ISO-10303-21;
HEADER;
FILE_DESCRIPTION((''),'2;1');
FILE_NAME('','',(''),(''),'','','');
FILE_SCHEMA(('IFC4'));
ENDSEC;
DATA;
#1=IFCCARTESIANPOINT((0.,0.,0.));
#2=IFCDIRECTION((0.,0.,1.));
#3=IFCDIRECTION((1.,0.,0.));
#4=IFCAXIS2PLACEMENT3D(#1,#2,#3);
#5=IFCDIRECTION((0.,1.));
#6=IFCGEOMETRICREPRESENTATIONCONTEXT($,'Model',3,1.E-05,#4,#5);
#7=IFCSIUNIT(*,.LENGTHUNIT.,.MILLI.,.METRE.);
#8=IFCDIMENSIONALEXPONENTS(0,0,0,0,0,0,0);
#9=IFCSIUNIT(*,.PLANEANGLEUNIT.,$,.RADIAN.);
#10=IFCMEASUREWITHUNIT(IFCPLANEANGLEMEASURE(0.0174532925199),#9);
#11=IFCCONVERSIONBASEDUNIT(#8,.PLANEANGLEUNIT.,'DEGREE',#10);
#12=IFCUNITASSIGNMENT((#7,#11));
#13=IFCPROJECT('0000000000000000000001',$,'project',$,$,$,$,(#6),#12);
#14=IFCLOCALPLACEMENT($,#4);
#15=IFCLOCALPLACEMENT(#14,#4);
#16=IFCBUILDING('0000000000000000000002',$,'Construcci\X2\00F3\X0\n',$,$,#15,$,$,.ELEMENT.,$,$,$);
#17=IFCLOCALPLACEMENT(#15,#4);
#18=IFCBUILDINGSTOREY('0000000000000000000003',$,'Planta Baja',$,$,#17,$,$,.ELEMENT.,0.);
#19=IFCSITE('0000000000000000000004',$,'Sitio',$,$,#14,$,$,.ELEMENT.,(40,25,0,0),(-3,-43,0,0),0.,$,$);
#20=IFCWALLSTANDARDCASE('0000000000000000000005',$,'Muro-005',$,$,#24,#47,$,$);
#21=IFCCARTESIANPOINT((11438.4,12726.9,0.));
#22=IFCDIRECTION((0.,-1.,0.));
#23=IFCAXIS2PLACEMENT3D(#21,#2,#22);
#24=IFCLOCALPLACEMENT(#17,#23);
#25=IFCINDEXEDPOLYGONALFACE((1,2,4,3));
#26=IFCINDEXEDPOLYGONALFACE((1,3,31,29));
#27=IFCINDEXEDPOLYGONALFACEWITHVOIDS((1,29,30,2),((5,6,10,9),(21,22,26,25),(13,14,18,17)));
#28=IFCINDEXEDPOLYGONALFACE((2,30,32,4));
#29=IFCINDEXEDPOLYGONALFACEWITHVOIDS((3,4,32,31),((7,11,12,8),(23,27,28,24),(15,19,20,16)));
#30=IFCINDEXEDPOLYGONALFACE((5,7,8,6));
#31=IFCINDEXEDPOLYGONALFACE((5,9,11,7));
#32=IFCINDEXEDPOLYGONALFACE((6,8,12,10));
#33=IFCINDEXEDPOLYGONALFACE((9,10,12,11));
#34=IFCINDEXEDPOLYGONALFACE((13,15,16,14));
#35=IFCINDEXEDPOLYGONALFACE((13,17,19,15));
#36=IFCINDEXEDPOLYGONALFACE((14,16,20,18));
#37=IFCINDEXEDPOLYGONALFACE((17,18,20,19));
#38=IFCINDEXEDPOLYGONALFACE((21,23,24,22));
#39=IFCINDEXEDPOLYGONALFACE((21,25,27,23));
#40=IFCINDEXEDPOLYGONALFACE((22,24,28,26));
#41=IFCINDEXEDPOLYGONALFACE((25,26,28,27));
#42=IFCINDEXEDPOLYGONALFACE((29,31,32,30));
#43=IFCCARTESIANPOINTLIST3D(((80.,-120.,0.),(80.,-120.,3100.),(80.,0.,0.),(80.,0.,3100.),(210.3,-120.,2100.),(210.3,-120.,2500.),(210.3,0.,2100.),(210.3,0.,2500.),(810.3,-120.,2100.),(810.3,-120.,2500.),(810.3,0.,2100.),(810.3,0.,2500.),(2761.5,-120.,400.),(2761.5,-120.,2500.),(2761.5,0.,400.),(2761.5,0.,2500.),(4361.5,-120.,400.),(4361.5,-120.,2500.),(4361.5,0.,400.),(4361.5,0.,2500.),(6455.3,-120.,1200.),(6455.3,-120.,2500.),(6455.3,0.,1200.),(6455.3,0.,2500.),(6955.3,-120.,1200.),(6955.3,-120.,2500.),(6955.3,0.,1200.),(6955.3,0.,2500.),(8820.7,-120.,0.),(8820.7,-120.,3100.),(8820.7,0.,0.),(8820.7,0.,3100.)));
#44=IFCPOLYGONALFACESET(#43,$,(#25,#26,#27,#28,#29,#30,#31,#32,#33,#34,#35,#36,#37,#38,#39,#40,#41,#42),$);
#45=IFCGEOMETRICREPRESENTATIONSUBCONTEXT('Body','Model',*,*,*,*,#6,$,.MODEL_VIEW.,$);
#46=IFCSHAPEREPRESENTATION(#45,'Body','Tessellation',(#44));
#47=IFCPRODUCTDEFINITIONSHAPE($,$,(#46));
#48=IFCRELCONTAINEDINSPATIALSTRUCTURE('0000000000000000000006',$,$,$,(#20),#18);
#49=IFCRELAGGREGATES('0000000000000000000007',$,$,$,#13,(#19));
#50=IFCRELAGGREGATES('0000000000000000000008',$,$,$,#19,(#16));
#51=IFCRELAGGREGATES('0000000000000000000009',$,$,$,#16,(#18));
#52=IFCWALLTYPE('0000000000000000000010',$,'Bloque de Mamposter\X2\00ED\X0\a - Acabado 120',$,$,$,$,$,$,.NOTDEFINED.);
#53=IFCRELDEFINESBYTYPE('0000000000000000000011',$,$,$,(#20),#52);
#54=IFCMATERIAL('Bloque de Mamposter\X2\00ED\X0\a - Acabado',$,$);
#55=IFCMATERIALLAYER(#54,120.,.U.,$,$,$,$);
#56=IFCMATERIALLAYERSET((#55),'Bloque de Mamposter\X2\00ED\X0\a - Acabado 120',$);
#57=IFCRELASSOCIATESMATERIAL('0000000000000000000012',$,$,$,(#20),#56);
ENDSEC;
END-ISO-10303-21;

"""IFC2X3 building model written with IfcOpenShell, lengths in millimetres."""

from ifc_helpers import new_model, entity, si_unit, converted_unit, direction, frame, origin_with_axes, origin_2d_with_axis, place, context, subcontext, project, spatial, polyline, rectangle, outline, extrude, material, layer, layer_set, layer_usage, type_object, element, save


model = new_model("IFC2X3")

# Units and contexts
model_context = context("Model", 3, precision=1e-05, world=origin_with_axes(), true_north=direction((0.0, 1.0)))
body_context = subcontext(model_context, "Body", "Model", "MODEL_VIEW")
ifc_project = project(units=[si_unit("LENGTHUNIT", "METRE", prefix="MILLI"), converted_unit("PLANEANGLEUNIT", "DEGREE", entity("IfcPlaneAngleMeasure", 0.0174532925199), si_unit("PLANEANGLEUNIT", "RADIAN"), dimensions=[0, 0, 0, 0, 0, 0, 0])], contexts=[model_context])

# Site, building, storey
site_placement = place(None, origin_with_axes())
site = spatial("IfcSite", under=ifc_project, at=site_placement, Name="Sitio", CompositionType="ELEMENT", RefLatitude=(40, 25, 0, 0), RefLongitude=(-3, -43, 0, 0), RefElevation=0.0)
building_placement = place(site_placement, origin_with_axes())
building = spatial("IfcBuilding", under=site, at=building_placement, Name="Construcción", CompositionType="ELEMENT")
storey_placement = place(building_placement, origin_with_axes())
storey = spatial("IfcBuildingStorey", under=building, at=storey_placement, Name="Planta Baja", CompositionType="ELEMENT", Elevation=0.0)

# Shared definitions
ifc_material_1 = material(Name="Bloque de Mampostería - Acabado")

# Shared definitions
ifc_layer_1 = layer(ifc_material_1, 120.0, ventilated="UNKNOWN")
ifc_layer_set_1 = layer_set([ifc_layer_1], Name="Bloque de Mampostería - Acabado 120")
wall_type_1 = type_object("IfcWallType", Name="Bloque de Mampostería - Acabado 120", PredefinedType="NOTDEFINED")

# Wall, openings
ifc_layer_usage_1 = layer_usage(ifc_layer_set_1, "AXIS2", "POSITIVE", -120.0)
wall_1_placement = place(storey_placement, frame((11438.4, 12726.9, 0.0), z_axis=(0.0, 0.0, 1.0), x_axis=(0.0, -1.0, 0.0)))
wall_1 = element("IfcWallStandardCase", 1, at=wall_1_placement, inside=storey, type_object=wall_type_1, material=ifc_layer_usage_1, Name="Muro-005", context=body_context, shape_type="SweptSolid", body=[
    extrude(outline(polyline([(80.0, -120.0), (8820.7, -120.0), (8820.7, 0.0), (80.0, 0.0), (80.0, -120.0)])), origin_with_axes(), (0.0, 0.0, 1.0), 3100.0),
])
opening_1_placement = place(wall_1_placement, frame((6705.3, 0.0, 1200.0), z_axis=(0.0, 0.0, 1.0), x_axis=(1.0, 0.0, 0.0)))
element("IfcOpeningElement", 2, at=opening_1_placement, cuts=wall_1, context=body_context, shape_type="SweptSolid", body=[
    extrude(rectangle(XDim=500.0, YDim=1300.0, at=origin_2d_with_axis()), frame((0.0, 120.0, 650.0), z_axis=(0.0, 1.0, 0.0), x_axis=(-1.0, 0.0, 0.0)), (0.0, 0.0, -1.0), 360.0),
])
opening_2_placement = place(wall_1_placement, frame((510.3, 0.0, 2100.0), z_axis=(0.0, 0.0, 1.0), x_axis=(1.0, 0.0, 0.0)))
element("IfcOpeningElement", 3, at=opening_2_placement, cuts=wall_1, context=body_context, shape_type="SweptSolid", body=[
    extrude(rectangle(XDim=600.0, YDim=400.0, at=origin_2d_with_axis()), frame((0.0, 120.0, 200.0), z_axis=(0.0, 1.0, 0.0), x_axis=(1.0, 0.0, 0.0)), (0.0, 0.0, -1.0), 360.0),
])
opening_3_placement = place(wall_1_placement, frame((3561.5, 0.0, 400.0), z_axis=(0.0, 0.0, 1.0), x_axis=(1.0, 0.0, 0.0)))
element("IfcOpeningElement", 4, at=opening_3_placement, cuts=wall_1, context=body_context, shape_type="SweptSolid", body=[
    extrude(rectangle(XDim=1600.0, YDim=2100.0, at=origin_2d_with_axis()), frame((0.0, 120.0, 1050.0), z_axis=(0.0, 1.0, 0.0), x_axis=(1.0, 0.0, 0.0)), (0.0, 0.0, -1.0), 360.0),
])

save(model, "model.ifc")
